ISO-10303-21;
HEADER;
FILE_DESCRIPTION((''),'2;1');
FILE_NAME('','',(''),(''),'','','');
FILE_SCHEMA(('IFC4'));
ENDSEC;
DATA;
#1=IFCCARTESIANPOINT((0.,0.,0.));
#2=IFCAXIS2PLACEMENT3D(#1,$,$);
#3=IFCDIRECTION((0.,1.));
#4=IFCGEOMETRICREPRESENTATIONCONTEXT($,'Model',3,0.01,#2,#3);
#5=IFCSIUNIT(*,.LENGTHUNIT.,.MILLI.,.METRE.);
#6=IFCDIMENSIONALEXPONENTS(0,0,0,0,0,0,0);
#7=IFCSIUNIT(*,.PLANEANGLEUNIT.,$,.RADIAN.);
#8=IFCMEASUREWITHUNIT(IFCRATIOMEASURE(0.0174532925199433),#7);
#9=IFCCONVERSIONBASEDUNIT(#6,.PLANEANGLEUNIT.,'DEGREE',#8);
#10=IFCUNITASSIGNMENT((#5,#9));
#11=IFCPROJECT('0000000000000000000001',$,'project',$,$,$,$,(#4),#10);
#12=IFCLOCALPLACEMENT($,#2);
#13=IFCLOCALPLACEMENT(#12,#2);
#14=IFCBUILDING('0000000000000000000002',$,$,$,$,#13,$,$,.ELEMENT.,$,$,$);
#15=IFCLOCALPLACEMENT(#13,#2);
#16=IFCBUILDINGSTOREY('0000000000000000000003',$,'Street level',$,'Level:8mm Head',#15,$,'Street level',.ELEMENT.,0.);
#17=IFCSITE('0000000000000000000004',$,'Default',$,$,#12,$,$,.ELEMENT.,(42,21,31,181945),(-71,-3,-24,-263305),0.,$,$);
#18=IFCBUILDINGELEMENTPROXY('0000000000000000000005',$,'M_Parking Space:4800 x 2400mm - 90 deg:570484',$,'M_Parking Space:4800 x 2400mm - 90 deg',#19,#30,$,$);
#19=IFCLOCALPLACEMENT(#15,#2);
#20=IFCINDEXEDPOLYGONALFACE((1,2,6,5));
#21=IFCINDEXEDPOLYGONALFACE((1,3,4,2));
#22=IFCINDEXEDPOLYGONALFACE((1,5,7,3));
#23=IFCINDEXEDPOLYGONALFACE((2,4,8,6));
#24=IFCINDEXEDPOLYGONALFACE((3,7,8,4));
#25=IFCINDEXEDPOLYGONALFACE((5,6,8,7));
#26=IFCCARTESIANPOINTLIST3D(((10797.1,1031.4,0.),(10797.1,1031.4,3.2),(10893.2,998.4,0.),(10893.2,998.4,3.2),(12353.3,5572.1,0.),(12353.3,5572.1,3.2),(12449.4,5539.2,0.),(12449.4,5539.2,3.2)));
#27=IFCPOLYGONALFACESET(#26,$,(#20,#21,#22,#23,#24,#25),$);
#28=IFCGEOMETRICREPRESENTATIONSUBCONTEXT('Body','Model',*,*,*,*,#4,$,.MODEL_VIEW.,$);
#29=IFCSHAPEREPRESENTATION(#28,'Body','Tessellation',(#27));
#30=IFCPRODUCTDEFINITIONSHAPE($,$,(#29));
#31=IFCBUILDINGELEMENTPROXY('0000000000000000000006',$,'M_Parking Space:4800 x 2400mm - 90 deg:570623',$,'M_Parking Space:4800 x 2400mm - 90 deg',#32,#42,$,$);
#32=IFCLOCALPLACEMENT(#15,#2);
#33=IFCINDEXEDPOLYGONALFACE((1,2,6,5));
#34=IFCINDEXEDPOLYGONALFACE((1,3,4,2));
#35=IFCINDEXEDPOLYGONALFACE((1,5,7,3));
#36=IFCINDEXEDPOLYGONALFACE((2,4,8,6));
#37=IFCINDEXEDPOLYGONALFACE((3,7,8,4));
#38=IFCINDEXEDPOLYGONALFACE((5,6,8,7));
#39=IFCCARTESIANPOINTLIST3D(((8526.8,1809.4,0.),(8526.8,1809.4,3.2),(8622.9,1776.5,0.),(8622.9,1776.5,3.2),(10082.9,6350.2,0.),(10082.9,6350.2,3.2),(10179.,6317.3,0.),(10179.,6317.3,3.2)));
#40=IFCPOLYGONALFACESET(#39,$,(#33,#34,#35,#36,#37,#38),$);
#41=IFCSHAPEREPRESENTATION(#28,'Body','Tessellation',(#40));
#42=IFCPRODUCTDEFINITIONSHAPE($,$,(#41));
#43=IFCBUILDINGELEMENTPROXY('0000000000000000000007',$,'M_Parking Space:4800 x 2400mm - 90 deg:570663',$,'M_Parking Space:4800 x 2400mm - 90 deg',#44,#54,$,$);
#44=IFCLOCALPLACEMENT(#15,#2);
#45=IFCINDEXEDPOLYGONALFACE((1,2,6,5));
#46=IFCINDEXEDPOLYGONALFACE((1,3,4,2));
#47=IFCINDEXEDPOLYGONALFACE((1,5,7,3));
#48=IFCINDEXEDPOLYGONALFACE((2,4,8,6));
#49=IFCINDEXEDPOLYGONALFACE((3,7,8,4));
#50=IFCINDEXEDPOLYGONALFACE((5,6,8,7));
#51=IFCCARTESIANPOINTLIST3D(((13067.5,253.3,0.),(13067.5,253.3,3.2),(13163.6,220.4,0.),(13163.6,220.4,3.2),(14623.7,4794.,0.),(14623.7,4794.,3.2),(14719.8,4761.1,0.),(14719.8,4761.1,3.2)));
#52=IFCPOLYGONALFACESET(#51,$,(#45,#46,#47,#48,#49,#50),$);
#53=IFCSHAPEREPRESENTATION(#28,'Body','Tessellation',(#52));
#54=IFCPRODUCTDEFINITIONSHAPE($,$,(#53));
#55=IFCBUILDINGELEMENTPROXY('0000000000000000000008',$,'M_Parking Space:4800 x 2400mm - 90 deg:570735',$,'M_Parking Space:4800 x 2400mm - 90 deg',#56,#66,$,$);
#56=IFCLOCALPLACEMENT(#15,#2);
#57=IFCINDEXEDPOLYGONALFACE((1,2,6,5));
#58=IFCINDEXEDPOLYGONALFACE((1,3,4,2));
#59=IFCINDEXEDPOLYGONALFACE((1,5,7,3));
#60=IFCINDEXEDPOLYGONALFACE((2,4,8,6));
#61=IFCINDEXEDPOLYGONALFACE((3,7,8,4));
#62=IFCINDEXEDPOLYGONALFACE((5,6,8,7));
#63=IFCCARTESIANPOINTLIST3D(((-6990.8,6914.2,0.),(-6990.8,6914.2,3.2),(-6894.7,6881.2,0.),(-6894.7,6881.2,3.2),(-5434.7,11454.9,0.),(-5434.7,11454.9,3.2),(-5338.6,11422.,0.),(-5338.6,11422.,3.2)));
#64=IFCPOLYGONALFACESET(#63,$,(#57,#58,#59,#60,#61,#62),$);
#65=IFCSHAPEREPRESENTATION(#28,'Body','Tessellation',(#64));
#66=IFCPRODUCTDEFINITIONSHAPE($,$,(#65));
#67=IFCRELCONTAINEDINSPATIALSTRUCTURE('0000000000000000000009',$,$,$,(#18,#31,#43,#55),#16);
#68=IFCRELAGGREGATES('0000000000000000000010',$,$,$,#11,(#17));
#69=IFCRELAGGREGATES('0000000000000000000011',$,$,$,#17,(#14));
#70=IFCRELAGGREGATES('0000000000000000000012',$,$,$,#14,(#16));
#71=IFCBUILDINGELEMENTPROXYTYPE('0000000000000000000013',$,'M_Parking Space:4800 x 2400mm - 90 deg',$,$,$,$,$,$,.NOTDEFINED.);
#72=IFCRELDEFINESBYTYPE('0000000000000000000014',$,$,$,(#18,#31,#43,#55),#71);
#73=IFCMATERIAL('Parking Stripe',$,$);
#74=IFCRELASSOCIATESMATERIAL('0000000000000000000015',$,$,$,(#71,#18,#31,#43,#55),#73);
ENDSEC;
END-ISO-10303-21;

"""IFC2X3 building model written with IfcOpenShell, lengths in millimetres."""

from ifc_helpers import new_model, entity, si_unit, converted_unit, direction, frame, origin, origin_2d_with_axis, place, context, subcontext, project, spatial, rectangle, extrude, source, transform, mapped, material, type_object, type_shapes, element, save


model = new_model("IFC2X3")

# Units and contexts
model_context = context("Model", 3, precision=0.01, world=origin(), true_north=direction((0.0, 1.0)))
body_context = subcontext(model_context, "Body", "Model", "MODEL_VIEW")
ifc_project = project(units=[si_unit("LENGTHUNIT", "METRE", prefix="MILLI"), converted_unit("PLANEANGLEUNIT", "DEGREE", entity("IfcRatioMeasure", 0.0174532925199433), si_unit("PLANEANGLEUNIT", "RADIAN"), dimensions=[0, 0, 0, 0, 0, 0, 0])], contexts=[model_context])

# Site, building, storey
site_placement = place(None, origin())
site = spatial("IfcSite", under=ifc_project, at=site_placement, Name="Default", CompositionType="ELEMENT", RefLatitude=(42, 21, 31, 181945), RefLongitude=(-71, -3, -24, -263305), RefElevation=0.0)
building_placement = place(site_placement, origin())
building = spatial("IfcBuilding", under=site, at=building_placement, CompositionType="ELEMENT")
storey_placement = place(building_placement, origin())
storey = spatial("IfcBuildingStorey", under=building, at=storey_placement, Name="Street level", ObjectType="Level:8mm Head", LongName="Street level", CompositionType="ELEMENT", Elevation=0.0)

# Building element proxies
ifc_material_1 = material(Name="Parking Stripe")
building_element_proxy_type = type_object("IfcBuildingElementProxyType", Name="M_Parking Space:4800 x 2400mm - 90 deg", PredefinedType="NOTDEFINED", material=ifc_material_1)
shared_shape_1 = source(origin(), body_context, "Body", "SweptSolid", [
    extrude(rectangle(XDim=101.6, YDim=4800.0, at=origin_2d_with_axis()), frame((0.0, 2400.0, 0.0)), (0.0, 0.0, 1.0), 3.2),
])
type_shapes(building_element_proxy_type, [shared_shape_1])
for number, where, z_axis, x_axis, name in (
    (1, (10845.2, 1014.9, 0.0), (0.0, 0.0, 1.0), (0.945989, -0.324198, 0.0), "M_Parking Space:4800 x 2400mm - 90 deg:570484"),
    (2, (8574.8, 1793.0, 0.0), (0.0, 0.0, 1.0), (0.945989, -0.324198, 0.0), "M_Parking Space:4800 x 2400mm - 90 deg:570623"),
    (3, (13115.6, 236.8, 0.0), (0.0, 0.0, 1.0), (0.945989, -0.324198, 0.0), "M_Parking Space:4800 x 2400mm - 90 deg:570663"),
    (4, (-6942.8, 6897.7, 0.0), (0.0, 0.0, 1.0), (0.945989, -0.324198, 0.0), "M_Parking Space:4800 x 2400mm - 90 deg:570735"),
):
    element("IfcBuildingElementProxy", number, at=place(storey_placement, frame(where, z_axis=z_axis, x_axis=x_axis)), inside=storey, type_object=building_element_proxy_type, material=ifc_material_1, Name=name, ObjectType="M_Parking Space:4800 x 2400mm - 90 deg", context=body_context, shape_type="MappedRepresentation", body=[
        mapped(shared_shape_1, transform((0.0, 0.0, 0.0), scale=1.0)),
    ])

save(model, "model.ifc")
